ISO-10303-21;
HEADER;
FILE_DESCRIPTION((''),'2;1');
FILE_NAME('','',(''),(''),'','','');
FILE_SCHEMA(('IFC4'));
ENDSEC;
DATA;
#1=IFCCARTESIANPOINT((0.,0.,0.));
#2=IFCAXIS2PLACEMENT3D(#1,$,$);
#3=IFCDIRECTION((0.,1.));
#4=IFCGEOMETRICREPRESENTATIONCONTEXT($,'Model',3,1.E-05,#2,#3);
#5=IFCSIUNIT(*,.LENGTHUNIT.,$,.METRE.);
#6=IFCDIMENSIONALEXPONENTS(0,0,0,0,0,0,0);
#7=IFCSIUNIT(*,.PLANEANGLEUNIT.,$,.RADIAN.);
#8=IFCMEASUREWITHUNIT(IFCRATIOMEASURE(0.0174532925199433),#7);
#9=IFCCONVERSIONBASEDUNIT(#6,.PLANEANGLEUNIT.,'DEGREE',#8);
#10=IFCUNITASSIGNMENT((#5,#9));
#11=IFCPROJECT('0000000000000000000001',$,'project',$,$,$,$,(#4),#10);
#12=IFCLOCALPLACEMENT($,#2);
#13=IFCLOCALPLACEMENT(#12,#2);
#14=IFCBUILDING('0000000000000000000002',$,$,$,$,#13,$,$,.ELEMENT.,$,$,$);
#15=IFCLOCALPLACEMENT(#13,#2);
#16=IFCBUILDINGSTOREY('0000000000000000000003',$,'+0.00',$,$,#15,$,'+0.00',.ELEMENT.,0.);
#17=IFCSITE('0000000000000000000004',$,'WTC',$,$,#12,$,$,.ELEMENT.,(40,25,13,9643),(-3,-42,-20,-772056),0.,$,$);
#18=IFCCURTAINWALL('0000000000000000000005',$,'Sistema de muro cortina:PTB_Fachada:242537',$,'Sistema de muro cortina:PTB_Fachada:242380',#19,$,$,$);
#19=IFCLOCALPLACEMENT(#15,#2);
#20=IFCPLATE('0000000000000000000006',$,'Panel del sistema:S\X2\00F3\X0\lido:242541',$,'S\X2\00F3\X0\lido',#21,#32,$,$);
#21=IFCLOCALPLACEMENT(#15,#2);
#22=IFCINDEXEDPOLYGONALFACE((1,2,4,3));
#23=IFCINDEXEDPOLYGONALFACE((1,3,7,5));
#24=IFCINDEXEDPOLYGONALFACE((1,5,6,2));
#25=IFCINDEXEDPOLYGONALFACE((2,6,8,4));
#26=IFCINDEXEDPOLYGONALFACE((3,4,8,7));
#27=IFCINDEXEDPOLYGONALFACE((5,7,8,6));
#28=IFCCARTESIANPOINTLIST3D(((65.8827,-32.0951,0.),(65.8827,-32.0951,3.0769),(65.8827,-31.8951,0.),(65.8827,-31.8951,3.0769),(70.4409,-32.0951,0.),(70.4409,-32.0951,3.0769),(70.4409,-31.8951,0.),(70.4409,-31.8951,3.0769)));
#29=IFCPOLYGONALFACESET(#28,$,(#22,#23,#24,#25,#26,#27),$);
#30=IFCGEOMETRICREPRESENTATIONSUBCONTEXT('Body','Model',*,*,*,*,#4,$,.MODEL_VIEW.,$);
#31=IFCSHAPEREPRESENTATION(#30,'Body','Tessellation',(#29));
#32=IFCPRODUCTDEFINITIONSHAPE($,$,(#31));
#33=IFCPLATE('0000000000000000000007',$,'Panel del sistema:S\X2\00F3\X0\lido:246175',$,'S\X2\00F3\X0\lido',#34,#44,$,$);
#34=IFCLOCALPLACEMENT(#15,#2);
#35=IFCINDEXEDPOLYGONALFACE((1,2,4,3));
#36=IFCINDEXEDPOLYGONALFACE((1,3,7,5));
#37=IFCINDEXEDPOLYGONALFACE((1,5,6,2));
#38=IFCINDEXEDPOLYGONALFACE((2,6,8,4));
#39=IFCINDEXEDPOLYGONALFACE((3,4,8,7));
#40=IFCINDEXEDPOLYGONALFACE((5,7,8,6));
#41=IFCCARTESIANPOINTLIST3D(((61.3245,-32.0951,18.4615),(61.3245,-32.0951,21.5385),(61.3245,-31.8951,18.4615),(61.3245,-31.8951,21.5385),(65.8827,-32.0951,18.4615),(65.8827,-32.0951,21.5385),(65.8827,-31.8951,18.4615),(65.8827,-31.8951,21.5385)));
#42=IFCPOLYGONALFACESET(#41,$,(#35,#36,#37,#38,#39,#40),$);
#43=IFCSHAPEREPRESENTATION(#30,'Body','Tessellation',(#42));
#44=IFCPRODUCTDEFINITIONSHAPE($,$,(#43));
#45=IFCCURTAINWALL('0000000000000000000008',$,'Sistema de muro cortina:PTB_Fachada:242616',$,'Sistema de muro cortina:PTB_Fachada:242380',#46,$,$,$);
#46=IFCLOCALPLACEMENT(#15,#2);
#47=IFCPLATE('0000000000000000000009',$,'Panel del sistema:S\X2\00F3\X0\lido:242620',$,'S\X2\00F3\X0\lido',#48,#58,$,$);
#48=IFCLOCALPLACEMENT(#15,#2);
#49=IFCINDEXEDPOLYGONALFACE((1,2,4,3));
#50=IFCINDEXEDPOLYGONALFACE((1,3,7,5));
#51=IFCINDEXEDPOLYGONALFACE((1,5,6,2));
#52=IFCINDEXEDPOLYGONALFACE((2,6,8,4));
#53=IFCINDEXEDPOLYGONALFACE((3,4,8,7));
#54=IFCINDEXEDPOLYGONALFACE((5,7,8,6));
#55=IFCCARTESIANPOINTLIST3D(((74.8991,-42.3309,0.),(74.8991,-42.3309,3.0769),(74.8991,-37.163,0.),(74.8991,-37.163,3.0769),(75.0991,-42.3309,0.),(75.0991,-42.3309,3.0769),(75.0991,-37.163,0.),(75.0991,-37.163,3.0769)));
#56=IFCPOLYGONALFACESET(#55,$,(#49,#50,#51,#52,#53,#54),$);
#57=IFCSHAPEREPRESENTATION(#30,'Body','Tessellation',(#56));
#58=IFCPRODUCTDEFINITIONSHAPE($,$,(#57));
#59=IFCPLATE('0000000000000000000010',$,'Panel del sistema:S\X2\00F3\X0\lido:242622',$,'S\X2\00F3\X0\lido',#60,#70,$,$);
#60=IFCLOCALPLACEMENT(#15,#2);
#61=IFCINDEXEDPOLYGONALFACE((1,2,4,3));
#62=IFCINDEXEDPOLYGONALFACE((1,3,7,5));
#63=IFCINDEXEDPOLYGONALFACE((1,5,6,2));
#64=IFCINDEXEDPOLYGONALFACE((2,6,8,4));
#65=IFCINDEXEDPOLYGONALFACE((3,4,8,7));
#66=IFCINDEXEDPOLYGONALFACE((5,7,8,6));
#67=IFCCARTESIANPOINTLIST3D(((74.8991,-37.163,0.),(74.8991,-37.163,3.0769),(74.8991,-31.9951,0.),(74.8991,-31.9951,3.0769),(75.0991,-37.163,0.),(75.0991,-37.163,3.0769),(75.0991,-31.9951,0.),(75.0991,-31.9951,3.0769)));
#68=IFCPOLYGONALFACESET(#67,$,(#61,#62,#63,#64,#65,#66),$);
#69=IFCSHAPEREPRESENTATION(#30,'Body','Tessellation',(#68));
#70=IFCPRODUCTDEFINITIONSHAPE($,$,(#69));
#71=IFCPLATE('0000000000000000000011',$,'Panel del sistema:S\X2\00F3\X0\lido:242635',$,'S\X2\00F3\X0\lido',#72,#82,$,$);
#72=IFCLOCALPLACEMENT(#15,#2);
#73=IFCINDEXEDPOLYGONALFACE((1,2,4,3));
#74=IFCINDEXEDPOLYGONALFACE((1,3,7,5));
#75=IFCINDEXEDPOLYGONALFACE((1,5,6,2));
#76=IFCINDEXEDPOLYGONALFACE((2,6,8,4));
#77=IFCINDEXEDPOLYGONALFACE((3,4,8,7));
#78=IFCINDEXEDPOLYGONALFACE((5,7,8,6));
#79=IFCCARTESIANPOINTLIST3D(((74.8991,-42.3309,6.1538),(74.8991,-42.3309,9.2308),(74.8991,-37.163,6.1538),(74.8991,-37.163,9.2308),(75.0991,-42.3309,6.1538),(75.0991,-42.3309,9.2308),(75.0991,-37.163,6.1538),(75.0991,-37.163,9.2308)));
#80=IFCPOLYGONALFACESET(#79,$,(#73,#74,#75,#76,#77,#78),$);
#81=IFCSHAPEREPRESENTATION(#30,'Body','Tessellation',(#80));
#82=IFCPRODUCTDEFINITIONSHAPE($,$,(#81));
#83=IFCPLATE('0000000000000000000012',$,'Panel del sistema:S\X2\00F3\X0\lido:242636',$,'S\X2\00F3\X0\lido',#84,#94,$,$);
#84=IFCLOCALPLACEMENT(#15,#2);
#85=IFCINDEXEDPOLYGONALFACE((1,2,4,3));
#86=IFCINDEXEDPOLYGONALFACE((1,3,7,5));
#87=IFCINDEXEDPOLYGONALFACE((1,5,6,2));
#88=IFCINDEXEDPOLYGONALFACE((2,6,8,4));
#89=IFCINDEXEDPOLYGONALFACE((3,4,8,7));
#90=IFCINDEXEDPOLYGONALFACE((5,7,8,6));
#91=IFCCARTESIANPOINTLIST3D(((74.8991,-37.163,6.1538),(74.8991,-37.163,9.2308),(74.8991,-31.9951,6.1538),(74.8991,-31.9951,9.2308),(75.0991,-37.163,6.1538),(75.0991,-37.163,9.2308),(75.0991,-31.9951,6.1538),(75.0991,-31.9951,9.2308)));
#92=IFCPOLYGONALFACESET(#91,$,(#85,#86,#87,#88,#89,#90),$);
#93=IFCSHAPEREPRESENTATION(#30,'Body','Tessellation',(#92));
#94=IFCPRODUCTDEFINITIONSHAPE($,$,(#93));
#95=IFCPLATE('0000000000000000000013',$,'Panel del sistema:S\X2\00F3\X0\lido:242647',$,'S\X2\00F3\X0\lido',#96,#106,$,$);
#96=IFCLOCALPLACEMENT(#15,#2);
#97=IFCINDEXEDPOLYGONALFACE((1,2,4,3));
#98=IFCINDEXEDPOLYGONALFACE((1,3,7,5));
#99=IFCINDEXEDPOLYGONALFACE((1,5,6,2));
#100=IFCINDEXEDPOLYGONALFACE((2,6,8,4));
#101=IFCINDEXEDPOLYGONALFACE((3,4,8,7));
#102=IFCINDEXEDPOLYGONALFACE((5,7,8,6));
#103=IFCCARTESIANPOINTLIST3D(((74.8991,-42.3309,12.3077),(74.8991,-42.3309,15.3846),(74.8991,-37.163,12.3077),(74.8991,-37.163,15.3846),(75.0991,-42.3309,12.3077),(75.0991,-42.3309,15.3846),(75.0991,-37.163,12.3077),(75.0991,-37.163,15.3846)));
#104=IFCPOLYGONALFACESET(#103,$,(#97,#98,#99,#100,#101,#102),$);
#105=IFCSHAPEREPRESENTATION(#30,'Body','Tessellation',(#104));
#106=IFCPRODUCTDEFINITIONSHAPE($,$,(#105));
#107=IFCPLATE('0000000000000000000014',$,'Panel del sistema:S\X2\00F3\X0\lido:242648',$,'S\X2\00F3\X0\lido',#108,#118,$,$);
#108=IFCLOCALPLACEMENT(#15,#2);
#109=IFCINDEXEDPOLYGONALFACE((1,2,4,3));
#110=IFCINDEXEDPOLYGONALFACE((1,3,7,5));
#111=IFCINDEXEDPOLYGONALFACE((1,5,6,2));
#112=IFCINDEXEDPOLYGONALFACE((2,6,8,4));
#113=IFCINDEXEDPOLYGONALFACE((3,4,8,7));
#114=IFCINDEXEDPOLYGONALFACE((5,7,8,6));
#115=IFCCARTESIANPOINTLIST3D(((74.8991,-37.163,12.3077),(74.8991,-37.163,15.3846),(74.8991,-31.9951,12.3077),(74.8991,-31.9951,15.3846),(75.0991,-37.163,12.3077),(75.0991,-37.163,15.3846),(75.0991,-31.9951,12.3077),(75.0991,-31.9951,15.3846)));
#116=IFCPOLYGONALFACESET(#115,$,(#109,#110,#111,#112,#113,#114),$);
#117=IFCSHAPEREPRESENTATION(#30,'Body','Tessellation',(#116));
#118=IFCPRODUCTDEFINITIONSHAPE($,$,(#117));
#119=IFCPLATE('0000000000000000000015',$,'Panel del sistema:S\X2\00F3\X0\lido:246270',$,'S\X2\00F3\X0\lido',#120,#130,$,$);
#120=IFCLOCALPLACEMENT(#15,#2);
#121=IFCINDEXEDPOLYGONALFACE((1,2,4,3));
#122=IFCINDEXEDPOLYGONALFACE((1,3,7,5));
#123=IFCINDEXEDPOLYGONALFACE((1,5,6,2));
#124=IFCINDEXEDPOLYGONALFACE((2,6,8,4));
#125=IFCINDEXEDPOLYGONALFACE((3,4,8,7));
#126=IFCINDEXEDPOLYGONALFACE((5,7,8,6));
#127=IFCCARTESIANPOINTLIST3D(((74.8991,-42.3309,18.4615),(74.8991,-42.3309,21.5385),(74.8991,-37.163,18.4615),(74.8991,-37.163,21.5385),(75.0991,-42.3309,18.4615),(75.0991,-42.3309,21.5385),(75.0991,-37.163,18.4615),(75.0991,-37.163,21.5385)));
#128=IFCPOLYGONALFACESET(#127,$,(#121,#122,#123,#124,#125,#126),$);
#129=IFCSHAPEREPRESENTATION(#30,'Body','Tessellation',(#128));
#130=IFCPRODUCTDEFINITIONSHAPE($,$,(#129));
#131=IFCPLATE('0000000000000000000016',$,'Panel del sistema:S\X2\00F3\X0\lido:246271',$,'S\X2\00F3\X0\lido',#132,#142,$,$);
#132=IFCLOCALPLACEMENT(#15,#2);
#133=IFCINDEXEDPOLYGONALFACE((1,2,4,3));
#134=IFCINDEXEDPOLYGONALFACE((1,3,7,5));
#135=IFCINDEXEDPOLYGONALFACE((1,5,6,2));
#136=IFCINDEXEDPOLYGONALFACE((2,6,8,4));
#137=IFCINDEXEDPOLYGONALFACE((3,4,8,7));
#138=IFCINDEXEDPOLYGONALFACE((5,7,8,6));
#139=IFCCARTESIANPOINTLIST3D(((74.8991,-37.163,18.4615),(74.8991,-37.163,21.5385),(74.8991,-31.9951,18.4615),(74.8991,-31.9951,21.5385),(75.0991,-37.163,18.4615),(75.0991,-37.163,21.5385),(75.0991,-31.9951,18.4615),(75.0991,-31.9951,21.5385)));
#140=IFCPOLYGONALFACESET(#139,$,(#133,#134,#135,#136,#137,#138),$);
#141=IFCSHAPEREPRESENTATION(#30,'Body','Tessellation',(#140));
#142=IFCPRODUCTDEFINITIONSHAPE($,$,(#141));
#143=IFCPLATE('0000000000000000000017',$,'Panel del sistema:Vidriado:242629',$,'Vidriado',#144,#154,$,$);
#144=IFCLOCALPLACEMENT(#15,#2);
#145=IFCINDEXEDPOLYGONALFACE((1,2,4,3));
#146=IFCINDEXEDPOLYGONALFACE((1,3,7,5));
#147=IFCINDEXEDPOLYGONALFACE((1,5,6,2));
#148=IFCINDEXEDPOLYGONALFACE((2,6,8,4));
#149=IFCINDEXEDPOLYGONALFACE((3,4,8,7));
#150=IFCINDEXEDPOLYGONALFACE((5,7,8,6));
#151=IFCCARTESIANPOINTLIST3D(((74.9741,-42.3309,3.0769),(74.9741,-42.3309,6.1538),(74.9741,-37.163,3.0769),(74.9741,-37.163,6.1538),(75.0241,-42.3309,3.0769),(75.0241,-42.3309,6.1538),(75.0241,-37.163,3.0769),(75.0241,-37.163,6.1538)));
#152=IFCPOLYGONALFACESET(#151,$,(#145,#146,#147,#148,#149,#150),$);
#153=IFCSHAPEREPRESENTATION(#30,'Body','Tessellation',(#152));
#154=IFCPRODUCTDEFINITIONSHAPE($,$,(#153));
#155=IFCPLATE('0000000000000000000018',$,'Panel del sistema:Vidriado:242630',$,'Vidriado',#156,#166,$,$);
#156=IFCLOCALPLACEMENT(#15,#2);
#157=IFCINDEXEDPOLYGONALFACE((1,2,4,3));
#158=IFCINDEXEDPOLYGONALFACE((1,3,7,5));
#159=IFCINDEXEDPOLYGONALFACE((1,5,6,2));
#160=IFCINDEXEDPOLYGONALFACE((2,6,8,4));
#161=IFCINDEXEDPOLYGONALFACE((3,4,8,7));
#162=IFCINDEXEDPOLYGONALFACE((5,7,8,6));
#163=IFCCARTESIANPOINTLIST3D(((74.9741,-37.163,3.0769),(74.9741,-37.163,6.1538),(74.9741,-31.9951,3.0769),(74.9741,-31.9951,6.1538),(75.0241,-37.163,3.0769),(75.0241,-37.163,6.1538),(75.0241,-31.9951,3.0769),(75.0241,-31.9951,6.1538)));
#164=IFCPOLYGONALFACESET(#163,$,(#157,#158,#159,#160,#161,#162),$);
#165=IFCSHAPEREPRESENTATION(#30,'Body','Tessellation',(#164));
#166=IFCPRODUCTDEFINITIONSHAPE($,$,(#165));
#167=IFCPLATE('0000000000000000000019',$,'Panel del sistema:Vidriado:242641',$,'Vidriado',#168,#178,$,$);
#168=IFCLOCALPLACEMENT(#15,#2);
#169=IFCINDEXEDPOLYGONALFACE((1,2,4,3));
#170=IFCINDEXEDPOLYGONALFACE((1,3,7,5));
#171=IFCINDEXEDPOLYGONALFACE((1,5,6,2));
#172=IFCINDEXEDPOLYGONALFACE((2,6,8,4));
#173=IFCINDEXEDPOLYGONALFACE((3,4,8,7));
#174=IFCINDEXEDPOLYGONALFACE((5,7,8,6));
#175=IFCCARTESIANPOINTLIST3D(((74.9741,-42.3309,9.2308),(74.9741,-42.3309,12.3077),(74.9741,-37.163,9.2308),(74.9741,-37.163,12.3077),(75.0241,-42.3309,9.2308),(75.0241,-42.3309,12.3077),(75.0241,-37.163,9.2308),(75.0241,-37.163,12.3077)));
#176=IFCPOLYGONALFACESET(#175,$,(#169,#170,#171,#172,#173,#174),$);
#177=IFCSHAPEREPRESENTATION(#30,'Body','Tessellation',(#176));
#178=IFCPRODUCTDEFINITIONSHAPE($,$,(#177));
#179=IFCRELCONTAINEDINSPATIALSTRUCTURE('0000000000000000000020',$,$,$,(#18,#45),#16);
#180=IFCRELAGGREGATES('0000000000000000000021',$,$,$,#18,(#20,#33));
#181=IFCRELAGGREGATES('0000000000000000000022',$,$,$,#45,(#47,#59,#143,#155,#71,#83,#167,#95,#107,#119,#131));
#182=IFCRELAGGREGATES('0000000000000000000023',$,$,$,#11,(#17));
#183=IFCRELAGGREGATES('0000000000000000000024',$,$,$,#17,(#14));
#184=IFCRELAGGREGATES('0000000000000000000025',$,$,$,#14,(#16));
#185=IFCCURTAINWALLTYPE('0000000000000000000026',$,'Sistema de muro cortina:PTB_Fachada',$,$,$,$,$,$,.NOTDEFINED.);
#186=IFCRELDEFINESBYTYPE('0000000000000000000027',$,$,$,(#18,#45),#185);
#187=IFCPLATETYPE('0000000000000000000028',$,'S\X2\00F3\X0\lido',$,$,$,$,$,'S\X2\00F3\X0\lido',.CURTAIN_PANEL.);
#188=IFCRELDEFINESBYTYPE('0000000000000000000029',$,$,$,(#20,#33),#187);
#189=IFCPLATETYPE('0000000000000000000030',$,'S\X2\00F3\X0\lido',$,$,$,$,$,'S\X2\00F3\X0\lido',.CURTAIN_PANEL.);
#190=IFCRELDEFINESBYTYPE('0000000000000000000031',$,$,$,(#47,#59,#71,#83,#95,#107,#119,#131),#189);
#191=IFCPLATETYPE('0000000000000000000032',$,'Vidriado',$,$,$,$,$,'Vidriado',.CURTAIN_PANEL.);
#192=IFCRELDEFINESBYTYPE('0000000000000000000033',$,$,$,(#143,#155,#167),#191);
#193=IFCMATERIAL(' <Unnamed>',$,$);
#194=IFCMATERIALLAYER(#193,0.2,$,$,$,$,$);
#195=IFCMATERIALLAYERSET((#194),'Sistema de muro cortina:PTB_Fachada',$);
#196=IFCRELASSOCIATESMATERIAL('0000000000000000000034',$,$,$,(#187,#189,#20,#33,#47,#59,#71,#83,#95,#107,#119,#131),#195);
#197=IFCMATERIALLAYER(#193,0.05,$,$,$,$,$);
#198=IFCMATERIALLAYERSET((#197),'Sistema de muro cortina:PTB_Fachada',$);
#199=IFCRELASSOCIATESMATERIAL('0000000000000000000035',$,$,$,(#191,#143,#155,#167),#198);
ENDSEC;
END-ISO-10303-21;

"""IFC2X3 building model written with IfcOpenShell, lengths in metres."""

from ifc_helpers import new_model, entity, si_unit, converted_unit, direction, frame, origin, origin_2d_with_axis, place, context, subcontext, project, spatial, rectangle, extrude, source, transform, mapped, material, layer, layer_set, layer_usage, type_object, type_shapes, element, aggregate, save


model = new_model("IFC2X3")

# Units and contexts
model_context = context("Model", 3, precision=1e-05, world=origin(), true_north=direction((0.0, 1.0)))
body_context = subcontext(model_context, "Body", "Model", "MODEL_VIEW")
ifc_project = project(units=[si_unit("LENGTHUNIT", "METRE"), converted_unit("PLANEANGLEUNIT", "DEGREE", entity("IfcRatioMeasure", 0.0174532925199433), si_unit("PLANEANGLEUNIT", "RADIAN"), dimensions=[0, 0, 0, 0, 0, 0, 0])], contexts=[model_context])

# Site, building, storey
site_placement = place(None, origin())
site = spatial("IfcSite", under=ifc_project, at=site_placement, Name="WTC", CompositionType="ELEMENT", RefLatitude=(40, 25, 13, 9643), RefLongitude=(-3, -42, -20, -772056), RefElevation=0.0)
building_placement = place(site_placement, origin())
building = spatial("IfcBuilding", under=site, at=building_placement, CompositionType="ELEMENT")
storey_placement = place(building_placement, origin())
storey = spatial("IfcBuildingStorey", under=building, at=storey_placement, Name="+0.00", LongName="+0.00", CompositionType="ELEMENT", Elevation=0.0)

# Curtain walls, plates
curtain_wall_type = type_object("IfcCurtainWallType", Name="Sistema de muro cortina:PTB_Fachada", PredefinedType="NOTDEFINED")
ifc_material = material(Name=" <Unnamed>")
ifc_layer_1 = layer(ifc_material, 0.2)
ifc_layer_set_1 = layer_set([ifc_layer_1], Name="Sistema de muro cortina:PTB_Fachada")
ifc_layer_2 = layer(ifc_material, 0.05)
ifc_layer_set_2 = layer_set([ifc_layer_2], Name="Sistema de muro cortina:PTB_Fachada")
curtain_wall_1_placement = place(storey_placement, origin())
curtain_wall_1 = element("IfcCurtainWall", 1, at=curtain_wall_1_placement, inside=storey, type_object=curtain_wall_type, Name="Sistema de muro cortina:PTB_Fachada:242537", ObjectType="Sistema de muro cortina:PTB_Fachada:242380")
ifc_layer_usage_1 = layer_usage(ifc_layer_set_1, "AXIS3", "POSITIVE", 0.0)
plate_type_1 = type_object("IfcPlateType", Name="Sólido", ElementType="Sólido", PredefinedType="CURTAIN_PANEL", material=ifc_layer_set_1)
shared_shape_1 = source(origin(), body_context, "Body", "SweptSolid", [
    extrude(rectangle(XDim=0.2, YDim=4.5582, at=origin_2d_with_axis()), frame((0.0, 0.0, 0.0), z_axis=(0.0, 0.0, 1.0), x_axis=(0.0, 1.0, 0.0)), (0.0, 0.0, 1.0), 3.0769),
])
type_shapes(plate_type_1, [shared_shape_1])
plate_1_placement = place(curtain_wall_1_placement, frame((68.1618, -31.9951, 0.0), z_axis=(0.0, 0.0, 1.0), x_axis=(-1.0, 0.0, 0.0)))
plate_1 = element("IfcPlate", 2, at=plate_1_placement, type_object=plate_type_1, material=ifc_layer_usage_1, Name="Panel del sistema:Sólido:242541", ObjectType="Sólido", context=body_context, shape_type="MappedRepresentation", body=[
    mapped(shared_shape_1, transform((0.0, 0.0, 0.0), scale=1.0)),
])
ifc_layer_usage_2 = layer_usage(ifc_layer_set_1, "AXIS3", "POSITIVE", 0.0)
plate_2_placement = place(curtain_wall_1_placement, frame((63.6036, -31.9951, 18.4615), z_axis=(0.0, 0.0, 1.0), x_axis=(-1.0, 0.0, 0.0)))
plate_2 = element("IfcPlate", 3, at=plate_2_placement, type_object=plate_type_1, material=ifc_layer_usage_2, Name="Panel del sistema:Sólido:246175", ObjectType="Sólido", context=body_context, shape_type="MappedRepresentation", body=[
    mapped(shared_shape_1, transform((0.0, 0.0, 0.0), scale=1.0)),
])
aggregate(curtain_wall_1, [plate_1, plate_2])
curtain_wall_2_placement = place(storey_placement, origin())
curtain_wall_2 = element("IfcCurtainWall", 4, at=curtain_wall_2_placement, inside=storey, type_object=curtain_wall_type, Name="Sistema de muro cortina:PTB_Fachada:242616", ObjectType="Sistema de muro cortina:PTB_Fachada:242380")
ifc_layer_usage_3 = layer_usage(ifc_layer_set_1, "AXIS3", "POSITIVE", 0.0)
plate_type_2 = type_object("IfcPlateType", Name="Sólido", ElementType="Sólido", PredefinedType="CURTAIN_PANEL", material=ifc_layer_set_1)
shared_shape_2 = source(origin(), body_context, "Body", "SweptSolid", [
    extrude(rectangle(XDim=0.2, YDim=5.1679, at=origin_2d_with_axis()), frame((0.0, 0.0, 0.0), z_axis=(0.0, 0.0, 1.0), x_axis=(0.0, 1.0, 0.0)), (0.0, 0.0, 1.0), 3.0769),
])
type_shapes(plate_type_2, [shared_shape_2])
plate_3_placement = place(curtain_wall_2_placement, frame((74.9991, -39.747, 0.0), z_axis=(0.0, 0.0, 1.0), x_axis=(0.0, 1.0, 0.0)))
plate_3 = element("IfcPlate", 5, at=plate_3_placement, type_object=plate_type_2, material=ifc_layer_usage_3, Name="Panel del sistema:Sólido:242620", ObjectType="Sólido", context=body_context, shape_type="MappedRepresentation", body=[
    mapped(shared_shape_2, transform((0.0, 0.0, 0.0), scale=1.0)),
])
ifc_layer_usage_4 = layer_usage(ifc_layer_set_1, "AXIS3", "POSITIVE", 0.0)
plate_4_placement = place(curtain_wall_2_placement, frame((74.9991, -34.5791, 0.0), z_axis=(0.0, 0.0, 1.0), x_axis=(0.0, 1.0, 0.0)))
plate_4 = element("IfcPlate", 6, at=plate_4_placement, type_object=plate_type_2, material=ifc_layer_usage_4, Name="Panel del sistema:Sólido:242622", ObjectType="Sólido", context=body_context, shape_type="MappedRepresentation", body=[
    mapped(shared_shape_2, transform((0.0, 0.0, 0.0), scale=1.0)),
])
ifc_layer_usage_5 = layer_usage(ifc_layer_set_1, "AXIS3", "POSITIVE", 0.0)
plate_5_placement = place(curtain_wall_2_placement, frame((74.9991, -39.747, 6.1538), z_axis=(0.0, 0.0, 1.0), x_axis=(0.0, 1.0, 0.0)))
plate_5 = element("IfcPlate", 7, at=plate_5_placement, type_object=plate_type_2, material=ifc_layer_usage_5, Name="Panel del sistema:Sólido:242635", ObjectType="Sólido", context=body_context, shape_type="MappedRepresentation", body=[
    mapped(shared_shape_2, transform((0.0, 0.0, 0.0), scale=1.0)),
])
ifc_layer_usage_6 = layer_usage(ifc_layer_set_1, "AXIS3", "POSITIVE", 0.0)
plate_6_placement = place(curtain_wall_2_placement, frame((74.9991, -34.5791, 6.1538), z_axis=(0.0, 0.0, 1.0), x_axis=(0.0, 1.0, 0.0)))
plate_6 = element("IfcPlate", 8, at=plate_6_placement, type_object=plate_type_2, material=ifc_layer_usage_6, Name="Panel del sistema:Sólido:242636", ObjectType="Sólido", context=body_context, shape_type="MappedRepresentation", body=[
    mapped(shared_shape_2, transform((0.0, 0.0, 0.0), scale=1.0)),
])
ifc_layer_usage_7 = layer_usage(ifc_layer_set_1, "AXIS3", "POSITIVE", 0.0)
plate_7_placement = place(curtain_wall_2_placement, frame((74.9991, -39.747, 12.3077), z_axis=(0.0, 0.0, 1.0), x_axis=(0.0, 1.0, 0.0)))
plate_7 = element("IfcPlate", 9, at=plate_7_placement, type_object=plate_type_2, material=ifc_layer_usage_7, Name="Panel del sistema:Sólido:242647", ObjectType="Sólido", context=body_context, shape_type="MappedRepresentation", body=[
    mapped(shared_shape_2, transform((0.0, 0.0, 0.0), scale=1.0)),
])
ifc_layer_usage_8 = layer_usage(ifc_layer_set_1, "AXIS3", "POSITIVE", 0.0)
plate_8_placement = place(curtain_wall_2_placement, frame((74.9991, -34.5791, 12.3077), z_axis=(0.0, 0.0, 1.0), x_axis=(0.0, 1.0, 0.0)))
plate_8 = element("IfcPlate", 10, at=plate_8_placement, type_object=plate_type_2, material=ifc_layer_usage_8, Name="Panel del sistema:Sólido:242648", ObjectType="Sólido", context=body_context, shape_type="MappedRepresentation", body=[
    mapped(shared_shape_2, transform((0.0, 0.0, 0.0), scale=1.0)),
])
ifc_layer_usage_9 = layer_usage(ifc_layer_set_1, "AXIS3", "POSITIVE", 0.0)
plate_9_placement = place(curtain_wall_2_placement, frame((74.9991, -39.747, 18.4615), z_axis=(0.0, 0.0, 1.0), x_axis=(0.0, 1.0, 0.0)))
plate_9 = element("IfcPlate", 11, at=plate_9_placement, type_object=plate_type_2, material=ifc_layer_usage_9, Name="Panel del sistema:Sólido:246270", ObjectType="Sólido", context=body_context, shape_type="MappedRepresentation", body=[
    mapped(shared_shape_2, transform((0.0, 0.0, 0.0), scale=1.0)),
])
ifc_layer_usage_10 = layer_usage(ifc_layer_set_1, "AXIS3", "POSITIVE", 0.0)
plate_10_placement = place(curtain_wall_2_placement, frame((74.9991, -34.5791, 18.4615), z_axis=(0.0, 0.0, 1.0), x_axis=(0.0, 1.0, 0.0)))
plate_10 = element("IfcPlate", 12, at=plate_10_placement, type_object=plate_type_2, material=ifc_layer_usage_10, Name="Panel del sistema:Sólido:246271", ObjectType="Sólido", context=body_context, shape_type="MappedRepresentation", body=[
    mapped(shared_shape_2, transform((0.0, 0.0, 0.0), scale=1.0)),
])
ifc_layer_usage_11 = layer_usage(ifc_layer_set_2, "AXIS3", "POSITIVE", 0.0)
plate_type_3 = type_object("IfcPlateType", Name="Vidriado", ElementType="Vidriado", PredefinedType="CURTAIN_PANEL", material=ifc_layer_set_2)
shared_shape_3 = source(origin(), body_context, "Body", "SweptSolid", [
    extrude(rectangle(XDim=0.05, YDim=5.1679, at=origin_2d_with_axis()), frame((0.0, 0.0, 0.0), z_axis=(0.0, 0.0, 1.0), x_axis=(0.0, 1.0, 0.0)), (0.0, 0.0, 1.0), 3.0769),
])
type_shapes(plate_type_3, [shared_shape_3])
plate_11_placement = place(curtain_wall_2_placement, frame((74.9991, -39.747, 3.0769), z_axis=(0.0, 0.0, 1.0), x_axis=(0.0, 1.0, 0.0)))
plate_11 = element("IfcPlate", 13, at=plate_11_placement, type_object=plate_type_3, material=ifc_layer_usage_11, Name="Panel del sistema:Vidriado:242629", ObjectType="Vidriado", context=body_context, shape_type="MappedRepresentation", body=[
    mapped(shared_shape_3, transform((0.0, 0.0, 0.0), scale=1.0)),
])
ifc_layer_usage_12 = layer_usage(ifc_layer_set_2, "AXIS3", "POSITIVE", 0.0)
plate_12_placement = place(curtain_wall_2_placement, frame((74.9991, -34.5791, 3.0769), z_axis=(0.0, 0.0, 1.0), x_axis=(0.0, 1.0, 0.0)))
plate_12 = element("IfcPlate", 14, at=plate_12_placement, type_object=plate_type_3, material=ifc_layer_usage_12, Name="Panel del sistema:Vidriado:242630", ObjectType="Vidriado", context=body_context, shape_type="MappedRepresentation", body=[
    mapped(shared_shape_3, transform((0.0, 0.0, 0.0), scale=1.0)),
])
ifc_layer_usage_13 = layer_usage(ifc_layer_set_2, "AXIS3", "POSITIVE", 0.0)
plate_13_placement = place(curtain_wall_2_placement, frame((74.9991, -39.747, 9.2308), z_axis=(0.0, 0.0, 1.0), x_axis=(0.0, 1.0, 0.0)))
plate_13 = element("IfcPlate", 15, at=plate_13_placement, type_object=plate_type_3, material=ifc_layer_usage_13, Name="Panel del sistema:Vidriado:242641", ObjectType="Vidriado", context=body_context, shape_type="MappedRepresentation", body=[
    mapped(shared_shape_3, transform((0.0, 0.0, 0.0), scale=1.0)),
])
aggregate(curtain_wall_2, [plate_3, plate_4, plate_11, plate_12, plate_5, plate_6, plate_13, plate_7, plate_8, plate_9, plate_10])

save(model, "model.ifc")
